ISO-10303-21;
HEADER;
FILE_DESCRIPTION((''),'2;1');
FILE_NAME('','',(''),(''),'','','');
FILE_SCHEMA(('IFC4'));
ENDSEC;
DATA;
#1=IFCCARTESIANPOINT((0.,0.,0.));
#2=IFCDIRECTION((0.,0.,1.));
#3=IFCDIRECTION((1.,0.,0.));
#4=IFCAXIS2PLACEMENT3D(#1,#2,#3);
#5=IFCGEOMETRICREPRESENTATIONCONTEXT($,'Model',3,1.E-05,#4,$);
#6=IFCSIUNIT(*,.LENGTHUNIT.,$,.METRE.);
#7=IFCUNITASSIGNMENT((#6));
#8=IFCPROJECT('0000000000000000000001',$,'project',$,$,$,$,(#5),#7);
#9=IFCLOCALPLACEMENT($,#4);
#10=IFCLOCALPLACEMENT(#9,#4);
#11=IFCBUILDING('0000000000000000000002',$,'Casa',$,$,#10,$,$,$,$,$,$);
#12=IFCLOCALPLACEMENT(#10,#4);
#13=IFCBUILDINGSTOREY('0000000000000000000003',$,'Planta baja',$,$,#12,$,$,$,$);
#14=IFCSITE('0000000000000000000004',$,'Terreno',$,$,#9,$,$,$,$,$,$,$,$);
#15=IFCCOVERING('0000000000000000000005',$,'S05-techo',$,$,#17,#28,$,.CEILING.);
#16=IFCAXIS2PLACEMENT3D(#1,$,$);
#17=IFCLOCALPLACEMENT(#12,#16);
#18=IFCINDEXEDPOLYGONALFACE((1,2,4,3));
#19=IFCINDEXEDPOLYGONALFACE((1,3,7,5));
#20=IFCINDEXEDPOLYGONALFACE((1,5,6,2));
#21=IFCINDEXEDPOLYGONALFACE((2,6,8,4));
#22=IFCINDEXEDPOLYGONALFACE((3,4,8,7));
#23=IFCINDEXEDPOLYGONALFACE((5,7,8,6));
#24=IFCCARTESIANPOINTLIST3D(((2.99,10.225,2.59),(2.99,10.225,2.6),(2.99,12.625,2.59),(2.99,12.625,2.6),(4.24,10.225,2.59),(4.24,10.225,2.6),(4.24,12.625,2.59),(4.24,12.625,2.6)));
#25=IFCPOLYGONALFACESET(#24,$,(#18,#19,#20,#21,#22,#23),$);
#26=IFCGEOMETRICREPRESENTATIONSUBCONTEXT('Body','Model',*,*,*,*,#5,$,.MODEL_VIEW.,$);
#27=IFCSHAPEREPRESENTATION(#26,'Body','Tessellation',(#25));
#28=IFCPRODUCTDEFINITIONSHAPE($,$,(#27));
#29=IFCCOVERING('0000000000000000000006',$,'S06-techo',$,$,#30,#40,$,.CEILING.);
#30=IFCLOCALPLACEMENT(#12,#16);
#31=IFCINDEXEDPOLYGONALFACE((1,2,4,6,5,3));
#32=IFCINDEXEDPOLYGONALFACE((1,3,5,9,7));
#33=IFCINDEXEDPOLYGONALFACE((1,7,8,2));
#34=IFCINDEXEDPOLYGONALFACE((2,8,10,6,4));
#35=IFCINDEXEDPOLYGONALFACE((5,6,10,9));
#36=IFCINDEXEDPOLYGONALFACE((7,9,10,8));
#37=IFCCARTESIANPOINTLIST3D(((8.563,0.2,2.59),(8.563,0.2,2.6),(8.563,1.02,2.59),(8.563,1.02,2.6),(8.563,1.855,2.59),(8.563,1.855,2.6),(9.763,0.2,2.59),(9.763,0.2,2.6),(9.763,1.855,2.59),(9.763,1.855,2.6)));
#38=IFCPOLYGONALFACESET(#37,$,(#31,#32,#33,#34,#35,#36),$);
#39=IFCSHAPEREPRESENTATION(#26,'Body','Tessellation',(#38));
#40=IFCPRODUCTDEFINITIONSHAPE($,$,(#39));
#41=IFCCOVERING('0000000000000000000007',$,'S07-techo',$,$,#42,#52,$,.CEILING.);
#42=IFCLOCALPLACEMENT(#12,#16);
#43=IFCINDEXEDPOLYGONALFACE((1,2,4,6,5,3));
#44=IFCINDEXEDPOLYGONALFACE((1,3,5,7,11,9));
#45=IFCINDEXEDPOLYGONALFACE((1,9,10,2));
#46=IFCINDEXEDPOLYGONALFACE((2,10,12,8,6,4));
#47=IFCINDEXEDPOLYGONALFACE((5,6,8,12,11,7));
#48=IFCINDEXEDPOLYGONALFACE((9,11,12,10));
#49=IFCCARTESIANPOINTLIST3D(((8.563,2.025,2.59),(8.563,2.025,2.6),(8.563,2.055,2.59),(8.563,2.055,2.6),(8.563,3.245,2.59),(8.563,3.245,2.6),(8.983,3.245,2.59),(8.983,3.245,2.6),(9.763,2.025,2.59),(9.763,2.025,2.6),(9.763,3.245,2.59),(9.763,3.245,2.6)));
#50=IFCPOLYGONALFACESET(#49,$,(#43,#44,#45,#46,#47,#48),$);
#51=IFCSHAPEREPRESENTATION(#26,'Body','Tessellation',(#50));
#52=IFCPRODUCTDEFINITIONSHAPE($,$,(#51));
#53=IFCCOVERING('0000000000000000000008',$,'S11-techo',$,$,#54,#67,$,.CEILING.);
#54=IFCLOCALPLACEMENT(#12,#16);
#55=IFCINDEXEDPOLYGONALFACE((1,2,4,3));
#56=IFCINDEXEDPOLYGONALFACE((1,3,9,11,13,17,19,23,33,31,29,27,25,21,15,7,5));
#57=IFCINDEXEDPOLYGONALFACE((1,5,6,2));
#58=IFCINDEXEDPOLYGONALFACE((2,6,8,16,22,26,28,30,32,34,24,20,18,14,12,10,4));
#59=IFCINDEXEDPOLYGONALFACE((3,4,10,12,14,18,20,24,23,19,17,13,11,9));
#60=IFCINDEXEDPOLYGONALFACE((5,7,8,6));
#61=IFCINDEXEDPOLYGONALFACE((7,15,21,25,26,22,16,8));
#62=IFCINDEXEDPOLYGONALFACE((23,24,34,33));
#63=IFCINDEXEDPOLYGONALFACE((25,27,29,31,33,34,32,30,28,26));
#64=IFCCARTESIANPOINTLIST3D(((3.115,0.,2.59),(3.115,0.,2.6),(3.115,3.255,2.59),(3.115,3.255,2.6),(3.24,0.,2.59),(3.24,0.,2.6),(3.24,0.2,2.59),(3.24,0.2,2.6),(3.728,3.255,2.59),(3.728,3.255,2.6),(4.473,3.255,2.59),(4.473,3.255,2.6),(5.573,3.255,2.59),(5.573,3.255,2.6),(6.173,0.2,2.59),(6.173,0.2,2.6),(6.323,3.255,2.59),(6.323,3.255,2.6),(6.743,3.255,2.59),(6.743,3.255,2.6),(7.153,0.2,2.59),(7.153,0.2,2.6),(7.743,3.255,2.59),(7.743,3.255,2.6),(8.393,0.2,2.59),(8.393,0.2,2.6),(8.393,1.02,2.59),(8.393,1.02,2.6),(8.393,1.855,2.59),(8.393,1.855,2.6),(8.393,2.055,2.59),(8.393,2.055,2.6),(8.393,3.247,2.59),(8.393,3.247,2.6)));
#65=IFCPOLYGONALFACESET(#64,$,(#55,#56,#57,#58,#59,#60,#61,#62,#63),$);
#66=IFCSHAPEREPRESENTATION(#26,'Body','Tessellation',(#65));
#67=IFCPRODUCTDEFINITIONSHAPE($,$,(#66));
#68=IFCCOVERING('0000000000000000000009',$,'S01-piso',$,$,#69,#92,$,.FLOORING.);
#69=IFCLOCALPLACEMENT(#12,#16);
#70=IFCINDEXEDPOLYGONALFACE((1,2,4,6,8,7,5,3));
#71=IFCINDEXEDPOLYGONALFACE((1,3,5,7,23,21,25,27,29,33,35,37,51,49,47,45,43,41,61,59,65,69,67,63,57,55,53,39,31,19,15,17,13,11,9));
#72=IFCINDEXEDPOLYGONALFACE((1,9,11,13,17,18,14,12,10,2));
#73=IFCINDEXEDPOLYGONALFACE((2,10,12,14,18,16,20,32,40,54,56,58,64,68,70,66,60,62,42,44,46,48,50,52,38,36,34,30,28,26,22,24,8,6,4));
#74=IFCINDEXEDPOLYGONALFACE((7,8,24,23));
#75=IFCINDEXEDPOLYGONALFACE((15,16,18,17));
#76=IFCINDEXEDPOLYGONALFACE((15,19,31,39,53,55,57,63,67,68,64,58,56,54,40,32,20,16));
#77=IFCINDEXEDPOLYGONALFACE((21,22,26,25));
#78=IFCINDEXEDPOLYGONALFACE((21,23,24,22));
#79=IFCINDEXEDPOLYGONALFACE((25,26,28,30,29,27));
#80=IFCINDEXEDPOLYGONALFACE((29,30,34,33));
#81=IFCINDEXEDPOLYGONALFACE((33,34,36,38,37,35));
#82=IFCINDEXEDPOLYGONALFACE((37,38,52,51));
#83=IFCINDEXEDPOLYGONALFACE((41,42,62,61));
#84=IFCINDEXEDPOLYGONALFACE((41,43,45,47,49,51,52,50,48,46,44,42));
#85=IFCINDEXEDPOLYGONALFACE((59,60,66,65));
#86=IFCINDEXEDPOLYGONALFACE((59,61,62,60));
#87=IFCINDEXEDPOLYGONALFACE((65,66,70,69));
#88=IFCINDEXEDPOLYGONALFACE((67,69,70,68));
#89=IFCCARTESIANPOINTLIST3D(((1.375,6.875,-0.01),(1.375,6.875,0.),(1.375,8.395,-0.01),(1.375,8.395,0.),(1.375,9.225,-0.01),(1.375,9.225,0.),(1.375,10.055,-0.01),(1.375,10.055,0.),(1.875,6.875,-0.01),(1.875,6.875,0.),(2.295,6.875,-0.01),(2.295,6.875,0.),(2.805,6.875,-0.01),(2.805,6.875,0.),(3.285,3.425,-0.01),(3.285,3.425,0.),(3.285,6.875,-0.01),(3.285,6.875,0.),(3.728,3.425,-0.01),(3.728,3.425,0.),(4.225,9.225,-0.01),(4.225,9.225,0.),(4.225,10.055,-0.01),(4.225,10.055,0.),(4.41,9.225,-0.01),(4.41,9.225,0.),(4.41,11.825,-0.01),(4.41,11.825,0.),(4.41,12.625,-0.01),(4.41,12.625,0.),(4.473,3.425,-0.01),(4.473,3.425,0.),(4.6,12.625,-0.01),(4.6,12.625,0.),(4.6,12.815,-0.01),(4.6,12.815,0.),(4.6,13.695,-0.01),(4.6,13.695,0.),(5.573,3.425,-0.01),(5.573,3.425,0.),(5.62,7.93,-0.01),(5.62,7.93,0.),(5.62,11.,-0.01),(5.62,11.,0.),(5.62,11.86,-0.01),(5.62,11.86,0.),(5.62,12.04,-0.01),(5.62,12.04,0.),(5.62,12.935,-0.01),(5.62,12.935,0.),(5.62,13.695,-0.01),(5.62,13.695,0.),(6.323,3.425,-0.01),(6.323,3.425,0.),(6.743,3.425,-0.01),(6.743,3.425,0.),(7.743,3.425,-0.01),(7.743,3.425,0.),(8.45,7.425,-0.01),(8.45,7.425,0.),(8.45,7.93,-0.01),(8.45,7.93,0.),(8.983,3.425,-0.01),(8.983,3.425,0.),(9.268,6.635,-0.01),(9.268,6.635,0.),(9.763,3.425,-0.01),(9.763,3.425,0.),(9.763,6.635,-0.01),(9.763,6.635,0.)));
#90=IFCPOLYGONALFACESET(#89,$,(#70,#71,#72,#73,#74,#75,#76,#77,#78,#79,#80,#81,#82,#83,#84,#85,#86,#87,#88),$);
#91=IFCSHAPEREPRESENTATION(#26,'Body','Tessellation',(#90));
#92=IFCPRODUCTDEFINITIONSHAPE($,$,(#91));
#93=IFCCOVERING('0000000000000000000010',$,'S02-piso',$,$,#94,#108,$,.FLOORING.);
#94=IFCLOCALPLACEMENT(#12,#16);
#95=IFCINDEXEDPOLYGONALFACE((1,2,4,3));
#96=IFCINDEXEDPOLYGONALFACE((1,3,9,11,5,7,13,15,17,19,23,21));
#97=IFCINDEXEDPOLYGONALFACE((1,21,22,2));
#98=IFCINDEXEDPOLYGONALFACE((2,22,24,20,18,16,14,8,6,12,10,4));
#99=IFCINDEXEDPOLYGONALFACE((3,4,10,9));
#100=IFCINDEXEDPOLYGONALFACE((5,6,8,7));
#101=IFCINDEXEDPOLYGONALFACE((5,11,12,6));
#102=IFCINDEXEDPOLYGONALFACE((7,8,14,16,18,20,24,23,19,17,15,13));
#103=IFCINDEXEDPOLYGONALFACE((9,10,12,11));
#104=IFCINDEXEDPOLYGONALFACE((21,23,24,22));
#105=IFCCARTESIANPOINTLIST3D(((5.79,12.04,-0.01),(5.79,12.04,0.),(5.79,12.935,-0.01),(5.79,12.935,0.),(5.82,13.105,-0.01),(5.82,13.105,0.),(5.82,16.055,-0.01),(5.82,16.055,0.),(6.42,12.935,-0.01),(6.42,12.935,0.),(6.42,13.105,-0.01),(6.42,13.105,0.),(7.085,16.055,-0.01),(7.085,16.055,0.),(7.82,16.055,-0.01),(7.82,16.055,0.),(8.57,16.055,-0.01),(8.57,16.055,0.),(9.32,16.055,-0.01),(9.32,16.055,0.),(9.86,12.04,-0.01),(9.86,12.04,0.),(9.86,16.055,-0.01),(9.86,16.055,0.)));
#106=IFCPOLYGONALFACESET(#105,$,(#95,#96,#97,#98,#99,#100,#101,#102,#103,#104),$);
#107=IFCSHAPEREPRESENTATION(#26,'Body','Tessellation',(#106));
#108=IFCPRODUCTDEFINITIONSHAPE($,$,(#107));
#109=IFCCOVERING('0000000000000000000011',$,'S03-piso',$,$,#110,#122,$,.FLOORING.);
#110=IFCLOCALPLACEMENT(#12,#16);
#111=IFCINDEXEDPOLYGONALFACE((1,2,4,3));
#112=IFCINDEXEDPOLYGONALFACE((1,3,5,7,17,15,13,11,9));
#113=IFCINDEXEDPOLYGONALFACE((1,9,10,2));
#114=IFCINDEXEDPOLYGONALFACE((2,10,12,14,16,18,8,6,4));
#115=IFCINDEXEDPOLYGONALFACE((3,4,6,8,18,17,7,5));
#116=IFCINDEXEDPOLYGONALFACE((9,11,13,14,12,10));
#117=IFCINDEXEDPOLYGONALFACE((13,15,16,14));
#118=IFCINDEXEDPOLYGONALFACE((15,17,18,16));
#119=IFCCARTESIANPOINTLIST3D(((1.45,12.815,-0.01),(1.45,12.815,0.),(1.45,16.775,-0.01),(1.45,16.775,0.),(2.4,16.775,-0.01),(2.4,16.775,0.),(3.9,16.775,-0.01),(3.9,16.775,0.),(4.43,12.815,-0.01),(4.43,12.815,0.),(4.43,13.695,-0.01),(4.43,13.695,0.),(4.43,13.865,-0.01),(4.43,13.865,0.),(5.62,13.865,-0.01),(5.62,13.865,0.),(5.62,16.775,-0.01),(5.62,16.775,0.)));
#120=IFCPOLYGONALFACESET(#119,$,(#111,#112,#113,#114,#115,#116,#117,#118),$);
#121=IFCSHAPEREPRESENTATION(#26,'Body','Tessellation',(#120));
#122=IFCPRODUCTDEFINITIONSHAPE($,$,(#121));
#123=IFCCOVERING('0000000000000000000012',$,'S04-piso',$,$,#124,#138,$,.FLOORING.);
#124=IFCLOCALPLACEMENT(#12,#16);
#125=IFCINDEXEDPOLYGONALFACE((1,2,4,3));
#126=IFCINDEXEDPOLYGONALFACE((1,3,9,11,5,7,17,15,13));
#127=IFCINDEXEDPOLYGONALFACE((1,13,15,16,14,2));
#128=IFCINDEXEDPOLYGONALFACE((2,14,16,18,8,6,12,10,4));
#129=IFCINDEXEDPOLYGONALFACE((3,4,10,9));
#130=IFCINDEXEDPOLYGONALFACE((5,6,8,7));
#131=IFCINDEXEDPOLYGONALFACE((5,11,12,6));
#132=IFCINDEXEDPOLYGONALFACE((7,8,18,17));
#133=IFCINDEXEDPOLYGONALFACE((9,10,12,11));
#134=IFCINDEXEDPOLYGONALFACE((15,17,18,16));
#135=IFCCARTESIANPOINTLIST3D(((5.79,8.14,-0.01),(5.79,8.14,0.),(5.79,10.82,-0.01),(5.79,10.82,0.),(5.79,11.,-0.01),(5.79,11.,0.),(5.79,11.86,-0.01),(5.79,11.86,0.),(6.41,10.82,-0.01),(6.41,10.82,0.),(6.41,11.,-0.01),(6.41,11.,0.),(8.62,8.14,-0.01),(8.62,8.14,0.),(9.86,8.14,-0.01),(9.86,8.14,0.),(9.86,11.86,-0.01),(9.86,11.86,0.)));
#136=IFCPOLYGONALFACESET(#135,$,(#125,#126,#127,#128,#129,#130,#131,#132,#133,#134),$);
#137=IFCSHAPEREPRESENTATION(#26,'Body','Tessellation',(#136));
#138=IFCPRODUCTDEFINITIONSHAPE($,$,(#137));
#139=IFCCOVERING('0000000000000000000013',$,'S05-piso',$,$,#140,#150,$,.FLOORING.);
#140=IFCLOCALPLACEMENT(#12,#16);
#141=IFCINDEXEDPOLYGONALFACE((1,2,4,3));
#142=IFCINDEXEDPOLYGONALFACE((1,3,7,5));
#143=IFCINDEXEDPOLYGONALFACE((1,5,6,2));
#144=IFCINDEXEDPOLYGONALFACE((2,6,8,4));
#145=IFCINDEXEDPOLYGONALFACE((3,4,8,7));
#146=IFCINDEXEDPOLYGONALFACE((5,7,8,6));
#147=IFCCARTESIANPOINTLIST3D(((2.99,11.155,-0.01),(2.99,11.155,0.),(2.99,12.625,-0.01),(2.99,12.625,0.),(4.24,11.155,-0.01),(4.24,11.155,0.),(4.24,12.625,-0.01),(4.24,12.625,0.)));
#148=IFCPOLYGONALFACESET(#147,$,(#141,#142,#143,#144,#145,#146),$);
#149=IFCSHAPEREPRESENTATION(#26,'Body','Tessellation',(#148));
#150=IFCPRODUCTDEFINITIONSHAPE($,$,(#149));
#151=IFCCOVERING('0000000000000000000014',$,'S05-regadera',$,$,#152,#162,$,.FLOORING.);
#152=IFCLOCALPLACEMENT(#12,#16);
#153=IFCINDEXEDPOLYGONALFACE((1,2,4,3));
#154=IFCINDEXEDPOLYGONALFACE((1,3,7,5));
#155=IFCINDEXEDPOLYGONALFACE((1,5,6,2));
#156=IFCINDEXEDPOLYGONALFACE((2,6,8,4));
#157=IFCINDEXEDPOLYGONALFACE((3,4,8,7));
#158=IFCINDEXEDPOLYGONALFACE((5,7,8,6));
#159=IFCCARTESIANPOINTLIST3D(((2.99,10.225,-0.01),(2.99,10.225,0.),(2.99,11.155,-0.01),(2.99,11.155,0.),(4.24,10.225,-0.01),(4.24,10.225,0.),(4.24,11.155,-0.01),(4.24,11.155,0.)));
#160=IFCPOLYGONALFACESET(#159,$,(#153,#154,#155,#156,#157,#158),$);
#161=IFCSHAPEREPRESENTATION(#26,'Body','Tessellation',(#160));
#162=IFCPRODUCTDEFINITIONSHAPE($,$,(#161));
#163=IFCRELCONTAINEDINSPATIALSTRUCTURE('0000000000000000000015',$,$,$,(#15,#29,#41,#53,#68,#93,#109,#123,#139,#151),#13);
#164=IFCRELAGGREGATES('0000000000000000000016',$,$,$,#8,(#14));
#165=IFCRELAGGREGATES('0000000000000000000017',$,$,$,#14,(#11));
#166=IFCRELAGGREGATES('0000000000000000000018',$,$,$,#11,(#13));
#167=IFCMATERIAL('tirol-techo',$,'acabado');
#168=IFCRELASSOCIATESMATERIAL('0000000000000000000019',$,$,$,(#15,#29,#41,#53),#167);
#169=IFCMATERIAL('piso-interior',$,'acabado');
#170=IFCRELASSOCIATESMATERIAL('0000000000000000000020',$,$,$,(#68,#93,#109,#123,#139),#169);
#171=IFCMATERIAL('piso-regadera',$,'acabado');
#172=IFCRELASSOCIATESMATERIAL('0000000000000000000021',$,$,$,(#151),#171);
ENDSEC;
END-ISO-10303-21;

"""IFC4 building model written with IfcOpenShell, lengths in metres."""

from ifc_helpers import new_model, si_unit, frame, origin_with_axes, place, context, subcontext, project, spatial, line, indexed_curve, outline, extrude, material, element, save


model = new_model("IFC4")

# Units and contexts
model_context = context("Model", 3, precision=1e-05, world=origin_with_axes())
body_context = subcontext(model_context, "Body", "Model", "MODEL_VIEW")
ifc_project = project(units=[si_unit("LENGTHUNIT", "METRE")], contexts=[model_context])

# Site, building, storey
site_placement = place(None, origin_with_axes())
site = spatial("IfcSite", under=ifc_project, at=site_placement, Name="Terreno")
building_placement = place(site_placement, origin_with_axes())
building = spatial("IfcBuilding", under=site, at=building_placement, Name="Casa")
storey_placement = place(building_placement, origin_with_axes())
storey = spatial("IfcBuildingStorey", under=building, at=storey_placement, Name="Planta baja")

# Coverings
ifc_material_1 = material(Name="tirol-techo", Category="acabado")
covering_1_placement = place(storey_placement, origin_with_axes())
element("IfcCovering", 1, at=covering_1_placement, inside=storey, material=ifc_material_1, Name="S05-techo", PredefinedType="CEILING", context=body_context, shape_type="SweptSolid", body=[
    extrude(outline(indexed_curve([(2.99, 12.625), (4.24, 12.625), (4.24, 10.225), (2.99, 10.225)], segments=[line(1, 2, 3, 4, 1)])), frame((0.0, 0.0, 2.59), z_axis=(0.0, 0.0, 1.0), x_axis=(1.0, 0.0, 0.0)), (0.0, 0.0, 1.0), 0.01),
])
covering_2_placement = place(storey_placement, origin_with_axes())
element("IfcCovering", 2, at=covering_2_placement, inside=storey, material=ifc_material_1, Name="S06-techo", PredefinedType="CEILING", context=body_context, shape_type="SweptSolid", body=[
    extrude(outline(indexed_curve([(8.563, 0.2), (8.563, 1.02), (8.563, 1.855), (9.763, 1.855), (9.763, 0.2)], segments=[line(1, 2, 3, 4, 5, 1)])), frame((0.0, 0.0, 2.59), z_axis=(0.0, 0.0, 1.0), x_axis=(1.0, 0.0, 0.0)), (0.0, 0.0, 1.0), 0.01),
])
covering_3_placement = place(storey_placement, origin_with_axes())
element("IfcCovering", 3, at=covering_3_placement, inside=storey, material=ifc_material_1, Name="S07-techo", PredefinedType="CEILING", context=body_context, shape_type="SweptSolid", body=[
    extrude(outline(indexed_curve([(8.563, 3.245), (8.983, 3.245), (9.763, 3.245), (9.763, 2.025), (8.563, 2.025), (8.563, 2.055)], segments=[line(1, 2, 3, 4, 5, 6, 1)])), frame((0.0, 0.0, 2.59), z_axis=(0.0, 0.0, 1.0), x_axis=(1.0, 0.0, 0.0)), (0.0, 0.0, 1.0), 0.01),
])
covering_4_placement = place(storey_placement, origin_with_axes())
element("IfcCovering", 4, at=covering_4_placement, inside=storey, material=ifc_material_1, Name="S11-techo", PredefinedType="CEILING", context=body_context, shape_type="SweptSolid", body=[
    extrude(outline(indexed_curve([(5.573, 3.255), (6.323, 3.255), (6.743, 3.255), (7.743, 3.255), (8.393, 3.247), (8.393, 2.055), (8.393, 1.855), (8.393, 1.02), (8.393, 0.2), (7.153, 0.2), (6.173, 0.2), (3.24, 0.2), (3.24, 0.0), (3.115, 0.0), (3.115, 3.255), (3.728, 3.255), (4.473, 3.255)], segments=[line(1, 2, 3, 4, 5, 6, 7, 8, 9, 10, 11, 12, 13, 14, 15, 16, 17, 1)])), frame((0.0, 0.0, 2.59), z_axis=(0.0, 0.0, 1.0), x_axis=(1.0, 0.0, 0.0)), (0.0, 0.0, 1.0), 0.01),
])
ifc_material_2 = material(Name="piso-interior", Category="acabado")
covering_5_placement = place(storey_placement, origin_with_axes())
element("IfcCovering", 5, at=covering_5_placement, inside=storey, material=ifc_material_2, Name="S01-piso", PredefinedType="FLOORING", context=body_context, shape_type="SweptSolid", body=[
    extrude(outline(indexed_curve([(4.6, 12.815), (4.6, 13.695), (5.62, 13.695), (5.62, 12.935), (5.62, 12.04), (5.62, 11.86), (5.62, 11.0), (5.62, 7.93), (8.45, 7.93), (8.45, 7.425), (9.268, 6.635), (9.763, 6.635), (9.763, 3.425), (8.983, 3.425), (7.743, 3.425), (6.743, 3.425), (6.323, 3.425), (5.573, 3.425), (4.473, 3.425), (3.728, 3.425), (3.285, 3.425), (3.285, 6.875), (2.805, 6.875), (2.295, 6.875), (1.875, 6.875), (1.375, 6.875), (1.375, 8.395), (1.375, 9.225), (1.375, 10.055), (4.225, 10.055), (4.225, 9.225), (4.41, 9.225), (4.41, 11.825), (4.41, 12.625), (4.6, 12.625)], segments=[line(1, 2, 3, 4, 5, 6, 7, 8, 9, 10, 11, 12, 13, 14, 15, 16, 17, 18, 19, 20, 21, 22, 23, 24, 25, 26, 27, 28, 29, 30, 31, 32, 33, 34, 35, 1)])), frame((0.0, 0.0, -0.01), z_axis=(0.0, 0.0, 1.0), x_axis=(1.0, 0.0, 0.0)), (0.0, 0.0, 1.0), 0.01),
])
covering_6_placement = place(storey_placement, origin_with_axes())
element("IfcCovering", 6, at=covering_6_placement, inside=storey, material=ifc_material_2, Name="S02-piso", PredefinedType="FLOORING", context=body_context, shape_type="SweptSolid", body=[
    extrude(outline(indexed_curve([(6.42, 12.935), (6.42, 13.105), (5.82, 13.105), (5.82, 16.055), (7.085, 16.055), (7.82, 16.055), (8.57, 16.055), (9.32, 16.055), (9.86, 16.055), (9.86, 12.04), (5.79, 12.04), (5.79, 12.935)], segments=[line(1, 2, 3, 4, 5, 6, 7, 8, 9, 10, 11, 12, 1)])), frame((0.0, 0.0, -0.01), z_axis=(0.0, 0.0, 1.0), x_axis=(1.0, 0.0, 0.0)), (0.0, 0.0, 1.0), 0.01),
])
covering_7_placement = place(storey_placement, origin_with_axes())
element("IfcCovering", 7, at=covering_7_placement, inside=storey, material=ifc_material_2, Name="S03-piso", PredefinedType="FLOORING", context=body_context, shape_type="SweptSolid", body=[
    extrude(outline(indexed_curve([(2.4, 16.775), (3.9, 16.775), (5.62, 16.775), (5.62, 13.865), (4.43, 13.865), (4.43, 13.695), (4.43, 12.815), (1.45, 12.815), (1.45, 16.775)], segments=[line(1, 2, 3, 4, 5, 6, 7, 8, 9, 1)])), frame((0.0, 0.0, -0.01), z_axis=(0.0, 0.0, 1.0), x_axis=(1.0, 0.0, 0.0)), (0.0, 0.0, 1.0), 0.01),
])
covering_8_placement = place(storey_placement, origin_with_axes())
element("IfcCovering", 8, at=covering_8_placement, inside=storey, material=ifc_material_2, Name="S04-piso", PredefinedType="FLOORING", context=body_context, shape_type="SweptSolid", body=[
    extrude(outline(indexed_curve([(6.41, 11.0), (5.79, 11.0), (5.79, 11.86), (9.86, 11.86), (9.86, 8.14), (8.62, 8.14), (5.79, 8.14), (5.79, 10.82), (6.41, 10.82)], segments=[line(1, 2, 3, 4, 5, 6, 7, 8, 9, 1)])), frame((0.0, 0.0, -0.01), z_axis=(0.0, 0.0, 1.0), x_axis=(1.0, 0.0, 0.0)), (0.0, 0.0, 1.0), 0.01),
])
covering_9_placement = place(storey_placement, origin_with_axes())
element("IfcCovering", 9, at=covering_9_placement, inside=storey, material=ifc_material_2, Name="S05-piso", PredefinedType="FLOORING", context=body_context, shape_type="SweptSolid", body=[
    extrude(outline(indexed_curve([(4.24, 12.625), (4.24, 11.155), (2.99, 11.155), (2.99, 12.625)], segments=[line(1, 2, 3, 4, 1)])), frame((0.0, 0.0, -0.01), z_axis=(0.0, 0.0, 1.0), x_axis=(1.0, 0.0, 0.0)), (0.0, 0.0, 1.0), 0.01),
])
ifc_material_3 = material(Name="piso-regadera", Category="acabado")
covering_10_placement = place(storey_placement, origin_with_axes())
element("IfcCovering", 10, at=covering_10_placement, inside=storey, material=ifc_material_3, Name="S05-regadera", PredefinedType="FLOORING", context=body_context, shape_type="SweptSolid", body=[
    extrude(outline(indexed_curve([(4.24, 10.225), (2.99, 10.225), (2.99, 11.155), (4.24, 11.155)], segments=[line(1, 2, 3, 4, 1)])), frame((0.0, 0.0, -0.01), z_axis=(0.0, 0.0, 1.0), x_axis=(1.0, 0.0, 0.0)), (0.0, 0.0, 1.0), 0.01),
])

save(model, "model.ifc")
